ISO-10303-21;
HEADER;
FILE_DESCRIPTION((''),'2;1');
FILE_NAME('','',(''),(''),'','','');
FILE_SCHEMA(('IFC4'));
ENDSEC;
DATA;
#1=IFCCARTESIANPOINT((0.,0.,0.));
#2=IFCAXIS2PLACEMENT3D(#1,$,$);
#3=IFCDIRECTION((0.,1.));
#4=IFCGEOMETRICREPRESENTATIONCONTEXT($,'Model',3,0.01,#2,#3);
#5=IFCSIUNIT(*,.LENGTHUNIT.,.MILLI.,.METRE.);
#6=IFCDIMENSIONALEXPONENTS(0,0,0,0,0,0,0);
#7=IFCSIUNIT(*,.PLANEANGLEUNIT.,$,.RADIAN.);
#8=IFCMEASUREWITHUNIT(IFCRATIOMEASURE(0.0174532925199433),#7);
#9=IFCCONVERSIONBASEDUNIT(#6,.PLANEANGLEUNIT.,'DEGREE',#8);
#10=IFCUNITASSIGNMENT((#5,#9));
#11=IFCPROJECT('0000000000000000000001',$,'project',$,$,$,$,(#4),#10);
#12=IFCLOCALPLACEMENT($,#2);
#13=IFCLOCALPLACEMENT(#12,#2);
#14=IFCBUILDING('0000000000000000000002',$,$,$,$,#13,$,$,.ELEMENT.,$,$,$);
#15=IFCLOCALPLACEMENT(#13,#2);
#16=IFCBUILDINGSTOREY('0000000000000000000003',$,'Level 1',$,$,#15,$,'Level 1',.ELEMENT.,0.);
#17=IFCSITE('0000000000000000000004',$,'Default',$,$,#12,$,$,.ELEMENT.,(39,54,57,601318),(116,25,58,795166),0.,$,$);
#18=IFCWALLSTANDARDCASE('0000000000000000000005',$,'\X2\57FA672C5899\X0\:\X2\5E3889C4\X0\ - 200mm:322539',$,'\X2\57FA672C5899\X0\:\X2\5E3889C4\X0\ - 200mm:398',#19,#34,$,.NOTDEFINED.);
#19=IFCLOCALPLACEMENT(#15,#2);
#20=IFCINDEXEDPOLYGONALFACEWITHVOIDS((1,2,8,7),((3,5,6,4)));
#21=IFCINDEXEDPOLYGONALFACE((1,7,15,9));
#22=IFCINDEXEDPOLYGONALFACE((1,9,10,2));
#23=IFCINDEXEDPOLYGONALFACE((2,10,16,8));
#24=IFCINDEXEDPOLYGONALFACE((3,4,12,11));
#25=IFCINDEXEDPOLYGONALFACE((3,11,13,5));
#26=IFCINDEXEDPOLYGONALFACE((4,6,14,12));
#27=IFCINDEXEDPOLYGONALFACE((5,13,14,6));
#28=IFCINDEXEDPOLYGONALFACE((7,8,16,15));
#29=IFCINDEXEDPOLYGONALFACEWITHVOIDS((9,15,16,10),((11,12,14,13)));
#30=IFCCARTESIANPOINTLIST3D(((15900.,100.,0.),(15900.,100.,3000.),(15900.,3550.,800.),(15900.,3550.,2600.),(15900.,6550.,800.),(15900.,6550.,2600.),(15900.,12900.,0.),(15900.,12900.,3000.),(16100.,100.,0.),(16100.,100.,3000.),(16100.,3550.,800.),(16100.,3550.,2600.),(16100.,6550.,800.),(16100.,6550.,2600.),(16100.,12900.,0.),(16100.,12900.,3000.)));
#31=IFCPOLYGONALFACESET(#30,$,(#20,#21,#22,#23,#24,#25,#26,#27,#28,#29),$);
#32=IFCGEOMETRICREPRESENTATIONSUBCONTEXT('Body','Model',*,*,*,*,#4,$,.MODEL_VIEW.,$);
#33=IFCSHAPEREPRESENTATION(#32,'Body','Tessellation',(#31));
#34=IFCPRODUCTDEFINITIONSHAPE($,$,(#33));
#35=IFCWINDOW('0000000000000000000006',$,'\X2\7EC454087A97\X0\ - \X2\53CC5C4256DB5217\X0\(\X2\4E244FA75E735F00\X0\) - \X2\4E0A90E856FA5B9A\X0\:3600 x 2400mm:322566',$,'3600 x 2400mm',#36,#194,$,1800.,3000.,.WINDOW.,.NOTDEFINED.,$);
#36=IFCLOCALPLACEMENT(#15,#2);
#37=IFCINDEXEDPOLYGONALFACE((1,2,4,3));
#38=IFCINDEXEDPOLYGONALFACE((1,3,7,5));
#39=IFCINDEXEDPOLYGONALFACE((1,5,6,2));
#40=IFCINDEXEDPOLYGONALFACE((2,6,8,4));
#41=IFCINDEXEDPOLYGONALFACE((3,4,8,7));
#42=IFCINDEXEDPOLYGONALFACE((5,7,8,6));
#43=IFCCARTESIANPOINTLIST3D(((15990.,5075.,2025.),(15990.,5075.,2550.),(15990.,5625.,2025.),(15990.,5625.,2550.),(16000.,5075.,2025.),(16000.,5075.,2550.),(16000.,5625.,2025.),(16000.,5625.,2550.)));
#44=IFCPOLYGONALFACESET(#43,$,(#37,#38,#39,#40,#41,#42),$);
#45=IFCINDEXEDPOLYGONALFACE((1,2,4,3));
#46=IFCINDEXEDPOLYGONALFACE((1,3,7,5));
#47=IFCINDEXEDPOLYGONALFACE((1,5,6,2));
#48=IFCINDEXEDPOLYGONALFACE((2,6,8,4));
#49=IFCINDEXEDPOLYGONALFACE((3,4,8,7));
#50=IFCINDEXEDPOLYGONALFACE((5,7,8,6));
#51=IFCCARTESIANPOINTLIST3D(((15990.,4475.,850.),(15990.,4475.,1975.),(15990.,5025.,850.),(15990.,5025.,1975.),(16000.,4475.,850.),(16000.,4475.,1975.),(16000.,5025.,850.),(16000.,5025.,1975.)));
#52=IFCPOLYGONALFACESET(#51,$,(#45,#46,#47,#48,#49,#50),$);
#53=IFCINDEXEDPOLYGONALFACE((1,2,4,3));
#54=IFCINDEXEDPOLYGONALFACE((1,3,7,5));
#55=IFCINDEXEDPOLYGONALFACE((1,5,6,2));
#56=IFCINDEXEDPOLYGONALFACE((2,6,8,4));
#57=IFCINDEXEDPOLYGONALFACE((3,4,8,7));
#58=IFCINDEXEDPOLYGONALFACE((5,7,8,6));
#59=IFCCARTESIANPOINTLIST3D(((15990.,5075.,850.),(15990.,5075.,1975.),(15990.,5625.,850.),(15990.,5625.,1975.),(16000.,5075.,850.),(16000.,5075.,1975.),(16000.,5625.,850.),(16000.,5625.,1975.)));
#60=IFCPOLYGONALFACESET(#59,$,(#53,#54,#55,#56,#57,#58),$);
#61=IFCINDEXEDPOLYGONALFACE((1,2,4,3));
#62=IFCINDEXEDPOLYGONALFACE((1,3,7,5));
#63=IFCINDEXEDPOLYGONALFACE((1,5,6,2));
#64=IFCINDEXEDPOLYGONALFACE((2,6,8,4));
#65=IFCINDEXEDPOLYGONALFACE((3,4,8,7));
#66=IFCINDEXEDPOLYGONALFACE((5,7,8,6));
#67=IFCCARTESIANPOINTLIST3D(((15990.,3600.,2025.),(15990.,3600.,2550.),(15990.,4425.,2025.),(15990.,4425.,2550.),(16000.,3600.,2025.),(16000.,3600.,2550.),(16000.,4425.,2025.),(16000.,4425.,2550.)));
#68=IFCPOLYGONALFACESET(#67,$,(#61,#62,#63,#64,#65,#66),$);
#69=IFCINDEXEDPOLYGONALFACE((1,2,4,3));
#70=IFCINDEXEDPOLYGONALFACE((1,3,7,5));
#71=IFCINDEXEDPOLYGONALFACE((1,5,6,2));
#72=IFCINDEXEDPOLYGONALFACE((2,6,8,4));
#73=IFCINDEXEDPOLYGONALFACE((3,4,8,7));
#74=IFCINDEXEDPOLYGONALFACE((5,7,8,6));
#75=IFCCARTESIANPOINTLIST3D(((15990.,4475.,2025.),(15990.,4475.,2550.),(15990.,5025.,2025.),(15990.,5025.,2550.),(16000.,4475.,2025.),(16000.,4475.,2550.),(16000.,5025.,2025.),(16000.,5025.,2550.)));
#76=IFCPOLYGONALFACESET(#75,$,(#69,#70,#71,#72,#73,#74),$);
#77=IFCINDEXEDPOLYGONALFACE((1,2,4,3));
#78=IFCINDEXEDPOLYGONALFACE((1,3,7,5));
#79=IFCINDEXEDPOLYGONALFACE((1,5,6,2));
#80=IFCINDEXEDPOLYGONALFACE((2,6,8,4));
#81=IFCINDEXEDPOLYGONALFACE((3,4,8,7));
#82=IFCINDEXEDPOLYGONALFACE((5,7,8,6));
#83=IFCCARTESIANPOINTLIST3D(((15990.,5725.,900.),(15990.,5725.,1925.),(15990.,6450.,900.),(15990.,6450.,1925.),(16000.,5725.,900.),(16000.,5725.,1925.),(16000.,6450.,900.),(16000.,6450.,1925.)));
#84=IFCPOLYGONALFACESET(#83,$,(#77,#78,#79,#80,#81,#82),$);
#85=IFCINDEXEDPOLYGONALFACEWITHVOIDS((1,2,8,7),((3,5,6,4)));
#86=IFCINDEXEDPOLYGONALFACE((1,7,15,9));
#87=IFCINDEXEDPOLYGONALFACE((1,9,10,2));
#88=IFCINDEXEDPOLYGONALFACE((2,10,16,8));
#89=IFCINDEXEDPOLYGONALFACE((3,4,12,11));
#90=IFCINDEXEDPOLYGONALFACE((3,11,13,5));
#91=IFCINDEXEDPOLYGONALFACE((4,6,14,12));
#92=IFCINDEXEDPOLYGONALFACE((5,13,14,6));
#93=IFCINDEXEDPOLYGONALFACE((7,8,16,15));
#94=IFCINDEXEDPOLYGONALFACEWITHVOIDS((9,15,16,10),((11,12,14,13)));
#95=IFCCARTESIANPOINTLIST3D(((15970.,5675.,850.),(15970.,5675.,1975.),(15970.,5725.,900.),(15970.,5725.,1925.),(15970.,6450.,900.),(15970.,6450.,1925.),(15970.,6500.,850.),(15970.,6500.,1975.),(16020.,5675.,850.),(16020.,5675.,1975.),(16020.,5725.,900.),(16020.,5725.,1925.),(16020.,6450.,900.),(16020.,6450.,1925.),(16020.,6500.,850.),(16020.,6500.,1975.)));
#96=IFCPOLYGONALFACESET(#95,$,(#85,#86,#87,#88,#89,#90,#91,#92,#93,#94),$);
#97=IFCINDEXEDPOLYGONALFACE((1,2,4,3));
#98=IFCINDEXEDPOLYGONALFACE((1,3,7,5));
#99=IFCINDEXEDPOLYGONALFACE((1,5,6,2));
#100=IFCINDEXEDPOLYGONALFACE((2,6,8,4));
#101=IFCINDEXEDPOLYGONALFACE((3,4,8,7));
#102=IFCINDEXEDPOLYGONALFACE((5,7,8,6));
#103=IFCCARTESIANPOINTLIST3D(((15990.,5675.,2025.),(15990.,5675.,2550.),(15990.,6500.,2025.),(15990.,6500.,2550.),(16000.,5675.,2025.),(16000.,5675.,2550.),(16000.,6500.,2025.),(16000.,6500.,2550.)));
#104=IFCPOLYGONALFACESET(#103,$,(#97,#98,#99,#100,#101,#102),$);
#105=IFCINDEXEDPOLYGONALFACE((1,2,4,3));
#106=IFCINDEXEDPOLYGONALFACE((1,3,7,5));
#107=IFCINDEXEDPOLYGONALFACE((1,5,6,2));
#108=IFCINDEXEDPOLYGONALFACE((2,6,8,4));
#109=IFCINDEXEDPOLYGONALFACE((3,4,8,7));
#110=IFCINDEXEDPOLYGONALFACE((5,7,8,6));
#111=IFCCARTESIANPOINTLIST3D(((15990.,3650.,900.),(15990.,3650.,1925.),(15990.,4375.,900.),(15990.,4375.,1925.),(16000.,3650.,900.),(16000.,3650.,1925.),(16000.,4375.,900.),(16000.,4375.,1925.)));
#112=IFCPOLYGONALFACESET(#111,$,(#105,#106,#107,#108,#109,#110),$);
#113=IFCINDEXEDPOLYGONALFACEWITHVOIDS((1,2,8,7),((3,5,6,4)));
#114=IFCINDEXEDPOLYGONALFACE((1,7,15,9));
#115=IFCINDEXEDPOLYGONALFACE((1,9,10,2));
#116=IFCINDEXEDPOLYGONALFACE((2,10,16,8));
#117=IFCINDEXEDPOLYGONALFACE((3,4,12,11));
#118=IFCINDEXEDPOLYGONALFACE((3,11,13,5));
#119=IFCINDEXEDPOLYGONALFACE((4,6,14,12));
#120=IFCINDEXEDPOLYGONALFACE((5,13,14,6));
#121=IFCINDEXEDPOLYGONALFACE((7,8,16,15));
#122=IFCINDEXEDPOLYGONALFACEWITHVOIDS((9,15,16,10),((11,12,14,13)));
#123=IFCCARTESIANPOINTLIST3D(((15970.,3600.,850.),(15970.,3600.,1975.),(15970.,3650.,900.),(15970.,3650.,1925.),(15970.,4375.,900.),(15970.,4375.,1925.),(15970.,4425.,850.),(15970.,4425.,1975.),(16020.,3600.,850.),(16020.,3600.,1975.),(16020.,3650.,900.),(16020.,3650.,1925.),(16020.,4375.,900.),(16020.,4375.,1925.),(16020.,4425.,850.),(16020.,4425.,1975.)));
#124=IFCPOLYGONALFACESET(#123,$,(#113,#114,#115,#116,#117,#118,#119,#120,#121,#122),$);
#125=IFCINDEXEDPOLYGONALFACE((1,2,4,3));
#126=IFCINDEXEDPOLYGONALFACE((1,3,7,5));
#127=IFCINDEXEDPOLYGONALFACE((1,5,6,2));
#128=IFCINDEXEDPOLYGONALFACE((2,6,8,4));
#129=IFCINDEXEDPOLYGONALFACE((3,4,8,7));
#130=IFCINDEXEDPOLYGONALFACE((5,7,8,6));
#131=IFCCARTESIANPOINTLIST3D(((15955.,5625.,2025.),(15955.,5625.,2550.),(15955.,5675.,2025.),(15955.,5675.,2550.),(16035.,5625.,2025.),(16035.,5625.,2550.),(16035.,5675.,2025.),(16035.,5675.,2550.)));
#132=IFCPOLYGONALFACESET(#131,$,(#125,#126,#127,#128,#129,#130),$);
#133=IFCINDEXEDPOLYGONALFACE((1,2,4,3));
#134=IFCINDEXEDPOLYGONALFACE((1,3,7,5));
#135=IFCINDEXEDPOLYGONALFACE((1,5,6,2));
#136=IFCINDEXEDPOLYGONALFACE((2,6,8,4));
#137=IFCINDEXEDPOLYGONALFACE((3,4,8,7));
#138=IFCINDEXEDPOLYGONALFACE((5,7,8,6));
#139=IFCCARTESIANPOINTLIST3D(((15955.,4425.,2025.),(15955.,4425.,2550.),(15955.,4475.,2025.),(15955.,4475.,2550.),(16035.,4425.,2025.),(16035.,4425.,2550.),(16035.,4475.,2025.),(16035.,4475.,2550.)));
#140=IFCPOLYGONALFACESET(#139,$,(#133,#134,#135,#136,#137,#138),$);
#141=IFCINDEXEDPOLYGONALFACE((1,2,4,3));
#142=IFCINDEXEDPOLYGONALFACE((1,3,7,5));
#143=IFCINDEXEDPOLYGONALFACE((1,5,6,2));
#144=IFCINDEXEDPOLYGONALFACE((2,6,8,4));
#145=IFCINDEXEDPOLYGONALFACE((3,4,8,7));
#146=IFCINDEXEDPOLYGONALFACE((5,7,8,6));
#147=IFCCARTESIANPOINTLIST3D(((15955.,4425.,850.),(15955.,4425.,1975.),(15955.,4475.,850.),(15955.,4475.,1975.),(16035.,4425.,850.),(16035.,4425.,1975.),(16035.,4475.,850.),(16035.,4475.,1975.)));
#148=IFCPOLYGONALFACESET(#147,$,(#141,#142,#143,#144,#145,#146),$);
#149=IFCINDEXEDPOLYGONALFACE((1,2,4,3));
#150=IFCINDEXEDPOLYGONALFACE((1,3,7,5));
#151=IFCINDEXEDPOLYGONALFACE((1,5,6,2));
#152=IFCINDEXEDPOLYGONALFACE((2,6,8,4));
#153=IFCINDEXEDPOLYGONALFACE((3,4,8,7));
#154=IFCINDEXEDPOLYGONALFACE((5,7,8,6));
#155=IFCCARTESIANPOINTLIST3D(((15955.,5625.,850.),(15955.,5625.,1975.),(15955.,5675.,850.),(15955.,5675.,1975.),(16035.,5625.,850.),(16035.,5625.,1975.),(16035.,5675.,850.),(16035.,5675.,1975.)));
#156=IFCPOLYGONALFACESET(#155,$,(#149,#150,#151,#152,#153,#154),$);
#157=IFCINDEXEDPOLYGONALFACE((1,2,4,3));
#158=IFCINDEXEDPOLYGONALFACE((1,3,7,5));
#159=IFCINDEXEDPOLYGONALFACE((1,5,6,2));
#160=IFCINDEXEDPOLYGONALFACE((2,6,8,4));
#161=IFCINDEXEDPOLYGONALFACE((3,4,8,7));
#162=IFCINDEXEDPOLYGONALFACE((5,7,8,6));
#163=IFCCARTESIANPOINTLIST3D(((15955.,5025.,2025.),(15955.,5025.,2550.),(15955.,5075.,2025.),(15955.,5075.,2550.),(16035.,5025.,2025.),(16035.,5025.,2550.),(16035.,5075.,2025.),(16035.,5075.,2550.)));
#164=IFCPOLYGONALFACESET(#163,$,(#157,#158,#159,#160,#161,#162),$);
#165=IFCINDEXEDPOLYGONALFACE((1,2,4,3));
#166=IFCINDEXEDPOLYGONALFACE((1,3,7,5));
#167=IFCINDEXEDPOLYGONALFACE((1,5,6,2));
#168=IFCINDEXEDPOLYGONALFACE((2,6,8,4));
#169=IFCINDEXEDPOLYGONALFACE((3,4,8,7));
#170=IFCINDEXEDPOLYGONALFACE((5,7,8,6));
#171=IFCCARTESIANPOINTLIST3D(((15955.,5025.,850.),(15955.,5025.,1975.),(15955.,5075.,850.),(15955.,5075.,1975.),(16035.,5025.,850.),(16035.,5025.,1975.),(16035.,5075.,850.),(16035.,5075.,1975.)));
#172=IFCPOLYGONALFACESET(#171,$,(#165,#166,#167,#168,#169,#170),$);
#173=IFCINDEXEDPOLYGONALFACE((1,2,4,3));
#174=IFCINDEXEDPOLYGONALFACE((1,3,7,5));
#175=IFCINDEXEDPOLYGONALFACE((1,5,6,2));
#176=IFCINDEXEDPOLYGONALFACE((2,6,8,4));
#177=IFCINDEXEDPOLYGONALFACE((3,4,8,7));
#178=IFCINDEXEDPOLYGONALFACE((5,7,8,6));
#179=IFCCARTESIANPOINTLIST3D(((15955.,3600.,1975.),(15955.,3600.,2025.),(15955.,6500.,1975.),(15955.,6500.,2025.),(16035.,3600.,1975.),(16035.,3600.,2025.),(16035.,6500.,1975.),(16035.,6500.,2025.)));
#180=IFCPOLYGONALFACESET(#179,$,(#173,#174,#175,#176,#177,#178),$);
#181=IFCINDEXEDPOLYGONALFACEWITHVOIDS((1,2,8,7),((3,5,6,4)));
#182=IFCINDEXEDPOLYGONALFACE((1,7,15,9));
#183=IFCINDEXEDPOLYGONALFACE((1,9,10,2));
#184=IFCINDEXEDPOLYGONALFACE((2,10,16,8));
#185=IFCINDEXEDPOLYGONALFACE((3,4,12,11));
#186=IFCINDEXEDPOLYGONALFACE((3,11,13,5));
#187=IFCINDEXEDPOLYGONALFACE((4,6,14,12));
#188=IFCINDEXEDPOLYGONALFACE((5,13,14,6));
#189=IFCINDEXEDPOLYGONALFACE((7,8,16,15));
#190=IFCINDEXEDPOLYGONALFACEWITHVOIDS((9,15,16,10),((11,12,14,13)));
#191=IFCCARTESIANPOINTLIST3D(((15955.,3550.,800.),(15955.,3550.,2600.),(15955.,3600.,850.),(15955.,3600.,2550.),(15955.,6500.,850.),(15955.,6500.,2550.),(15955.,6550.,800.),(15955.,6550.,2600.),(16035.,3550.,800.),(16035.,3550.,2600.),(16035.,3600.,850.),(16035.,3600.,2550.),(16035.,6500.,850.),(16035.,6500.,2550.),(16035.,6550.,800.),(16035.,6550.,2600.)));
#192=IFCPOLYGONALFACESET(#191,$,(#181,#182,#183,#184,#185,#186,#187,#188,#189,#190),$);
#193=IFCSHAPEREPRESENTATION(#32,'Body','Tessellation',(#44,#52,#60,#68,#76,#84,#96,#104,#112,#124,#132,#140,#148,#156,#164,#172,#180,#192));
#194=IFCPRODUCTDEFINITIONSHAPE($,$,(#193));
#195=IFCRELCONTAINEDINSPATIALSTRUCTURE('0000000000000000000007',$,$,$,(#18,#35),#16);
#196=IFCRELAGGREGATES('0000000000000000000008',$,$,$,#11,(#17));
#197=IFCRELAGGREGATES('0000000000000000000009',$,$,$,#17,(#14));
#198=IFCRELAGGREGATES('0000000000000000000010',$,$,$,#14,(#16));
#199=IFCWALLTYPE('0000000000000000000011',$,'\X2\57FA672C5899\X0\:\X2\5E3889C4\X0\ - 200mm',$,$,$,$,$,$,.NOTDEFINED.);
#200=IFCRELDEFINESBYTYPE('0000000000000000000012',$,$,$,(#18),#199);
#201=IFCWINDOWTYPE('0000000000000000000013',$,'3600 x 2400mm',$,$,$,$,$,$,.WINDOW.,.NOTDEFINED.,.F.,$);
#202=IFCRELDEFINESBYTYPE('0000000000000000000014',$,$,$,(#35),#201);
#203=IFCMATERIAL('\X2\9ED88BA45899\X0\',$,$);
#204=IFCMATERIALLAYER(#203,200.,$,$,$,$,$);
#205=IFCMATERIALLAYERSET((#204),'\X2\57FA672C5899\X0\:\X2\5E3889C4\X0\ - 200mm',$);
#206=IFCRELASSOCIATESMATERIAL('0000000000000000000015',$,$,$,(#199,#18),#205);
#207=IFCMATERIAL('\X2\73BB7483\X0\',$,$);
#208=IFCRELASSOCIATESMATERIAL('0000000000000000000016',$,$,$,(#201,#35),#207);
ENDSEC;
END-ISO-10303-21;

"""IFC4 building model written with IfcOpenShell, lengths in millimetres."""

from ifc_helpers import new_model, entity, si_unit, converted_unit, direction, frame, frame_2d, origin, origin_2d_with_axis, place, context, subcontext, project, spatial, polyline, rectangle, outline, extrude, source, transform, mapped, material, layer, layer_set, layer_usage, type_object, type_shapes, element, fill, save


model = new_model("IFC4")

# Units and contexts
model_context = context("Model", 3, precision=0.01, world=origin(), true_north=direction((0.0, 1.0)))
body_context = subcontext(model_context, "Body", "Model", "MODEL_VIEW")
ifc_project = project(units=[si_unit("LENGTHUNIT", "METRE", prefix="MILLI"), converted_unit("PLANEANGLEUNIT", "DEGREE", entity("IfcRatioMeasure", 0.0174532925199433), si_unit("PLANEANGLEUNIT", "RADIAN"), dimensions=[0, 0, 0, 0, 0, 0, 0])], contexts=[model_context])

# Site, building, storey
site_placement = place(None, origin())
site = spatial("IfcSite", under=ifc_project, at=site_placement, Name="Default", CompositionType="ELEMENT", RefLatitude=(39, 54, 57, 601318), RefLongitude=(116, 25, 58, 795166), RefElevation=0.0)
building_placement = place(site_placement, origin())
building = spatial("IfcBuilding", under=site, at=building_placement, CompositionType="ELEMENT")
storey_placement = place(building_placement, origin())
storey = spatial("IfcBuildingStorey", under=building, at=storey_placement, Name="Level 1", LongName="Level 1", CompositionType="ELEMENT", Elevation=0.0)

# Shared definitions
ifc_material_1 = material(Name="默认墙")
ifc_layer_1 = layer(ifc_material_1, 200.0)
ifc_layer_set_1 = layer_set([ifc_layer_1], Name="基本墙:常规 - 200mm")
wall_type = type_object("IfcWallType", Name="基本墙:常规 - 200mm", PredefinedType="NOTDEFINED", material=ifc_layer_set_1)
ifc_material_2 = material(Name="玻璃")
window_type_1 = type_object("IfcWindowType", Name="3600 x 2400mm", ParameterTakesPrecedence=False, PartitioningType="NOTDEFINED", PredefinedType="WINDOW", material=ifc_material_2)
shared_shape_1 = source(origin(), body_context, "Body", "SweptSolid", [
    extrude(rectangle(XDim=10.0, YDim=550.0, at=origin_2d_with_axis()), frame((1200.0, 95.0, 1225.0), z_axis=(0.0, 0.0, 1.0), x_axis=(0.0, 1.0, 0.0)), (0.0, 0.0, 1.0), 525.0),
    extrude(rectangle(XDim=10.0, YDim=550.0, at=origin_2d_with_axis()), frame((1800.0, 95.0, 50.0), z_axis=(0.0, 0.0, 1.0), x_axis=(0.0, 1.0, 0.0)), (0.0, 0.0, 1.0), 1125.0),
    extrude(rectangle(XDim=10.0, YDim=550.0, at=origin_2d_with_axis()), frame((1200.0, 95.0, 50.0), z_axis=(0.0, 0.0, 1.0), x_axis=(0.0, 1.0, 0.0)), (0.0, 0.0, 1.0), 1125.0),
    extrude(rectangle(XDim=10.0, YDim=825.0, at=frame_2d((0.0, 0.0), x_axis=(1.0, 0.0))), frame((2537.5, 95.0, 1225.0), z_axis=(0.0, 0.0, 1.0), x_axis=(0.0, 1.0, 0.0)), (0.0, 0.0, 1.0), 525.0),
    extrude(rectangle(XDim=10.0, YDim=550.0, at=frame_2d((0.0, 0.0), x_axis=(1.0, 0.0))), frame((1800.0, 95.0, 1225.0), z_axis=(0.0, 0.0, 1.0), x_axis=(0.0, 1.0, 0.0)), (0.0, 0.0, 1.0), 525.0),
    extrude(rectangle(XDim=10.0, YDim=725.0, at=frame_2d((0.0, 0.0), x_axis=(1.0, 0.0))), frame((462.5, 95.0, 100.0), z_axis=(0.0, 0.0, 1.0), x_axis=(0.0, 1.0, 0.0)), (0.0, 0.0, 1.0), 1025.0),
    extrude(outline(polyline([(-562.5, -412.5), (562.5, -412.5), (562.5, 412.5), (-562.5, 412.5), (-562.5, -412.5)]), holes=[polyline([(512.5, -362.5), (-512.5, -362.5), (-512.5, 362.5), (512.5, 362.5), (512.5, -362.5)])]), frame((462.5, 70.0, 612.5), z_axis=(0.0, 1.0, 0.0), x_axis=(0.0, 0.0, -1.0)), (0.0, 0.0, 1.0), 50.0),
    extrude(rectangle(XDim=10.0, YDim=825.0, at=origin_2d_with_axis()), frame((462.5, 95.0, 1225.0), z_axis=(0.0, 0.0, 1.0), x_axis=(0.0, 1.0, 0.0)), (0.0, 0.0, 1.0), 525.0),
    extrude(rectangle(XDim=10.0, YDim=725.0, at=frame_2d((0.0, 0.0), x_axis=(1.0, 0.0))), frame((2537.5, 95.0, 100.0), z_axis=(0.0, 0.0, 1.0), x_axis=(0.0, 1.0, 0.0)), (0.0, 0.0, 1.0), 1025.0),
    extrude(outline(polyline([(-562.5, -412.5), (562.5, -412.5), (562.5, 412.5), (-562.5, 412.5), (-562.5, -412.5)]), holes=[polyline([(512.5, -362.5), (-512.5, -362.5), (-512.5, 362.5), (512.5, 362.5), (512.5, -362.5)])]), frame((2537.5, 70.0, 612.5), z_axis=(0.0, 1.0, 0.0), x_axis=(0.0, 0.0, -1.0)), (0.0, 0.0, 1.0), 50.0),
    extrude(rectangle(XDim=80.0, YDim=50.0, at=origin_2d_with_axis()), frame((900.0, 95.0, 1225.0), z_axis=(0.0, 0.0, 1.0), x_axis=(0.0, -1.0, 0.0)), (0.0, 0.0, 1.0), 525.0),
    extrude(rectangle(XDim=80.0, YDim=50.0, at=frame_2d((0.0, 0.0), x_axis=(1.0, 0.0))), frame((2100.0, 95.0, 1225.0), z_axis=(0.0, 0.0, 1.0), x_axis=(0.0, -1.0, 0.0)), (0.0, 0.0, 1.0), 525.0),
    extrude(rectangle(XDim=80.0, YDim=50.0, at=origin_2d_with_axis()), frame((2100.0, 95.0, 50.0), z_axis=(0.0, 0.0, 1.0), x_axis=(0.0, -1.0, 0.0)), (0.0, 0.0, 1.0), 1125.0),
    extrude(rectangle(XDim=80.0, YDim=50.0, at=origin_2d_with_axis()), frame((900.0, 95.0, 50.0), z_axis=(0.0, 0.0, 1.0), x_axis=(0.0, -1.0, 0.0)), (0.0, 0.0, 1.0), 1125.0),
    extrude(rectangle(XDim=80.0, YDim=50.0, at=frame_2d((0.0, 0.0), x_axis=(1.0, 0.0))), frame((1500.0, 95.0, 1225.0), z_axis=(0.0, 0.0, 1.0), x_axis=(0.0, -1.0, 0.0)), (0.0, 0.0, 1.0), 525.0),
    extrude(rectangle(XDim=80.0, YDim=50.0, at=origin_2d_with_axis()), frame((1500.0, 95.0, 50.0), z_axis=(0.0, 0.0, 1.0), x_axis=(0.0, -1.0, 0.0)), (0.0, 0.0, 1.0), 1125.0),
    extrude(rectangle(XDim=80.0, YDim=2900.0, at=frame_2d((0.0, 0.0), x_axis=(1.0, 0.0))), frame((1500.0, 95.0, 1175.0), z_axis=(0.0, 0.0, 1.0), x_axis=(0.0, -1.0, 0.0)), (0.0, 0.0, 1.0), 50.0),
    extrude(outline(polyline([(-1500.0, -900.0), (1500.0, -900.0), (1500.0, 900.0), (-1500.0, 900.0), (-1500.0, -900.0)]), holes=[polyline([(1450.0, -850.0), (-1450.0, -850.0), (-1450.0, 850.0), (1450.0, 850.0), (1450.0, -850.0)])]), frame((1500.0, 55.0, 900.0), z_axis=(0.0, 1.0, 0.0), x_axis=(1.0, 0.0, 0.0)), (0.0, 0.0, 1.0), 80.0),
])
type_shapes(window_type_1, [shared_shape_1])

# Wall, opening, window
ifc_layer_usage_1 = layer_usage(ifc_layer_set_1, "AXIS2", "NEGATIVE", 100.0)
wall_1_placement = place(storey_placement, frame((16000.0, 12900.0, 0.0), z_axis=(0.0, 0.0, 1.0), x_axis=(0.0, -1.0, 0.0)))
wall_1 = element("IfcWallStandardCase", 1, at=wall_1_placement, inside=storey, type_object=wall_type, material=ifc_layer_usage_1, Name="基本墙:常规 - 200mm:322539", ObjectType="基本墙:常规 - 200mm:398", PredefinedType="NOTDEFINED", context=body_context, shape_type="SweptSolid", body=[
    extrude(rectangle(XDim=12800.0, YDim=200.0, at=frame_2d((6400.0, 0.0), x_axis=(-1.0, 0.0))), origin(), (0.0, 0.0, 1.0), 3000.0),
])
opening_1_placement = place(wall_1_placement, frame((6350.0, -100.0, 800.0)))
opening_1 = element("IfcOpeningElement", 2, at=opening_1_placement, cuts=wall_1, ObjectType="Opening", PredefinedType="OPENING", context=body_context, shape_type="SweptSolid", body=[
    extrude(rectangle(XDim=1800.0, YDim=3000.0, at=frame_2d((900.0, 1500.0), x_axis=(1.0, 0.0))), frame((0.0, 0.0, 0.0), z_axis=(0.0, 1.0, 0.0), x_axis=(0.0, 0.0, 1.0)), (0.0, 0.0, 1.0), 200.0),
])
window_1_placement = place(opening_1_placement, origin())
window_1 = element("IfcWindow", 3, at=window_1_placement, inside=storey, type_object=window_type_1, material=ifc_material_2, Name="组合窗 - 双层四列(两侧平开) - 上部固定:3600 x 2400mm:322566", ObjectType="3600 x 2400mm", OverallHeight=1800.0, OverallWidth=3000.0, PartitioningType="NOTDEFINED", PredefinedType="WINDOW", context=body_context, shape_type="MappedRepresentation", body=[
    mapped(shared_shape_1, transform((0.0, 0.0, 0.0), scale=1.0)),
])
fill(opening_1, window_1)

save(model, "model.ifc")
